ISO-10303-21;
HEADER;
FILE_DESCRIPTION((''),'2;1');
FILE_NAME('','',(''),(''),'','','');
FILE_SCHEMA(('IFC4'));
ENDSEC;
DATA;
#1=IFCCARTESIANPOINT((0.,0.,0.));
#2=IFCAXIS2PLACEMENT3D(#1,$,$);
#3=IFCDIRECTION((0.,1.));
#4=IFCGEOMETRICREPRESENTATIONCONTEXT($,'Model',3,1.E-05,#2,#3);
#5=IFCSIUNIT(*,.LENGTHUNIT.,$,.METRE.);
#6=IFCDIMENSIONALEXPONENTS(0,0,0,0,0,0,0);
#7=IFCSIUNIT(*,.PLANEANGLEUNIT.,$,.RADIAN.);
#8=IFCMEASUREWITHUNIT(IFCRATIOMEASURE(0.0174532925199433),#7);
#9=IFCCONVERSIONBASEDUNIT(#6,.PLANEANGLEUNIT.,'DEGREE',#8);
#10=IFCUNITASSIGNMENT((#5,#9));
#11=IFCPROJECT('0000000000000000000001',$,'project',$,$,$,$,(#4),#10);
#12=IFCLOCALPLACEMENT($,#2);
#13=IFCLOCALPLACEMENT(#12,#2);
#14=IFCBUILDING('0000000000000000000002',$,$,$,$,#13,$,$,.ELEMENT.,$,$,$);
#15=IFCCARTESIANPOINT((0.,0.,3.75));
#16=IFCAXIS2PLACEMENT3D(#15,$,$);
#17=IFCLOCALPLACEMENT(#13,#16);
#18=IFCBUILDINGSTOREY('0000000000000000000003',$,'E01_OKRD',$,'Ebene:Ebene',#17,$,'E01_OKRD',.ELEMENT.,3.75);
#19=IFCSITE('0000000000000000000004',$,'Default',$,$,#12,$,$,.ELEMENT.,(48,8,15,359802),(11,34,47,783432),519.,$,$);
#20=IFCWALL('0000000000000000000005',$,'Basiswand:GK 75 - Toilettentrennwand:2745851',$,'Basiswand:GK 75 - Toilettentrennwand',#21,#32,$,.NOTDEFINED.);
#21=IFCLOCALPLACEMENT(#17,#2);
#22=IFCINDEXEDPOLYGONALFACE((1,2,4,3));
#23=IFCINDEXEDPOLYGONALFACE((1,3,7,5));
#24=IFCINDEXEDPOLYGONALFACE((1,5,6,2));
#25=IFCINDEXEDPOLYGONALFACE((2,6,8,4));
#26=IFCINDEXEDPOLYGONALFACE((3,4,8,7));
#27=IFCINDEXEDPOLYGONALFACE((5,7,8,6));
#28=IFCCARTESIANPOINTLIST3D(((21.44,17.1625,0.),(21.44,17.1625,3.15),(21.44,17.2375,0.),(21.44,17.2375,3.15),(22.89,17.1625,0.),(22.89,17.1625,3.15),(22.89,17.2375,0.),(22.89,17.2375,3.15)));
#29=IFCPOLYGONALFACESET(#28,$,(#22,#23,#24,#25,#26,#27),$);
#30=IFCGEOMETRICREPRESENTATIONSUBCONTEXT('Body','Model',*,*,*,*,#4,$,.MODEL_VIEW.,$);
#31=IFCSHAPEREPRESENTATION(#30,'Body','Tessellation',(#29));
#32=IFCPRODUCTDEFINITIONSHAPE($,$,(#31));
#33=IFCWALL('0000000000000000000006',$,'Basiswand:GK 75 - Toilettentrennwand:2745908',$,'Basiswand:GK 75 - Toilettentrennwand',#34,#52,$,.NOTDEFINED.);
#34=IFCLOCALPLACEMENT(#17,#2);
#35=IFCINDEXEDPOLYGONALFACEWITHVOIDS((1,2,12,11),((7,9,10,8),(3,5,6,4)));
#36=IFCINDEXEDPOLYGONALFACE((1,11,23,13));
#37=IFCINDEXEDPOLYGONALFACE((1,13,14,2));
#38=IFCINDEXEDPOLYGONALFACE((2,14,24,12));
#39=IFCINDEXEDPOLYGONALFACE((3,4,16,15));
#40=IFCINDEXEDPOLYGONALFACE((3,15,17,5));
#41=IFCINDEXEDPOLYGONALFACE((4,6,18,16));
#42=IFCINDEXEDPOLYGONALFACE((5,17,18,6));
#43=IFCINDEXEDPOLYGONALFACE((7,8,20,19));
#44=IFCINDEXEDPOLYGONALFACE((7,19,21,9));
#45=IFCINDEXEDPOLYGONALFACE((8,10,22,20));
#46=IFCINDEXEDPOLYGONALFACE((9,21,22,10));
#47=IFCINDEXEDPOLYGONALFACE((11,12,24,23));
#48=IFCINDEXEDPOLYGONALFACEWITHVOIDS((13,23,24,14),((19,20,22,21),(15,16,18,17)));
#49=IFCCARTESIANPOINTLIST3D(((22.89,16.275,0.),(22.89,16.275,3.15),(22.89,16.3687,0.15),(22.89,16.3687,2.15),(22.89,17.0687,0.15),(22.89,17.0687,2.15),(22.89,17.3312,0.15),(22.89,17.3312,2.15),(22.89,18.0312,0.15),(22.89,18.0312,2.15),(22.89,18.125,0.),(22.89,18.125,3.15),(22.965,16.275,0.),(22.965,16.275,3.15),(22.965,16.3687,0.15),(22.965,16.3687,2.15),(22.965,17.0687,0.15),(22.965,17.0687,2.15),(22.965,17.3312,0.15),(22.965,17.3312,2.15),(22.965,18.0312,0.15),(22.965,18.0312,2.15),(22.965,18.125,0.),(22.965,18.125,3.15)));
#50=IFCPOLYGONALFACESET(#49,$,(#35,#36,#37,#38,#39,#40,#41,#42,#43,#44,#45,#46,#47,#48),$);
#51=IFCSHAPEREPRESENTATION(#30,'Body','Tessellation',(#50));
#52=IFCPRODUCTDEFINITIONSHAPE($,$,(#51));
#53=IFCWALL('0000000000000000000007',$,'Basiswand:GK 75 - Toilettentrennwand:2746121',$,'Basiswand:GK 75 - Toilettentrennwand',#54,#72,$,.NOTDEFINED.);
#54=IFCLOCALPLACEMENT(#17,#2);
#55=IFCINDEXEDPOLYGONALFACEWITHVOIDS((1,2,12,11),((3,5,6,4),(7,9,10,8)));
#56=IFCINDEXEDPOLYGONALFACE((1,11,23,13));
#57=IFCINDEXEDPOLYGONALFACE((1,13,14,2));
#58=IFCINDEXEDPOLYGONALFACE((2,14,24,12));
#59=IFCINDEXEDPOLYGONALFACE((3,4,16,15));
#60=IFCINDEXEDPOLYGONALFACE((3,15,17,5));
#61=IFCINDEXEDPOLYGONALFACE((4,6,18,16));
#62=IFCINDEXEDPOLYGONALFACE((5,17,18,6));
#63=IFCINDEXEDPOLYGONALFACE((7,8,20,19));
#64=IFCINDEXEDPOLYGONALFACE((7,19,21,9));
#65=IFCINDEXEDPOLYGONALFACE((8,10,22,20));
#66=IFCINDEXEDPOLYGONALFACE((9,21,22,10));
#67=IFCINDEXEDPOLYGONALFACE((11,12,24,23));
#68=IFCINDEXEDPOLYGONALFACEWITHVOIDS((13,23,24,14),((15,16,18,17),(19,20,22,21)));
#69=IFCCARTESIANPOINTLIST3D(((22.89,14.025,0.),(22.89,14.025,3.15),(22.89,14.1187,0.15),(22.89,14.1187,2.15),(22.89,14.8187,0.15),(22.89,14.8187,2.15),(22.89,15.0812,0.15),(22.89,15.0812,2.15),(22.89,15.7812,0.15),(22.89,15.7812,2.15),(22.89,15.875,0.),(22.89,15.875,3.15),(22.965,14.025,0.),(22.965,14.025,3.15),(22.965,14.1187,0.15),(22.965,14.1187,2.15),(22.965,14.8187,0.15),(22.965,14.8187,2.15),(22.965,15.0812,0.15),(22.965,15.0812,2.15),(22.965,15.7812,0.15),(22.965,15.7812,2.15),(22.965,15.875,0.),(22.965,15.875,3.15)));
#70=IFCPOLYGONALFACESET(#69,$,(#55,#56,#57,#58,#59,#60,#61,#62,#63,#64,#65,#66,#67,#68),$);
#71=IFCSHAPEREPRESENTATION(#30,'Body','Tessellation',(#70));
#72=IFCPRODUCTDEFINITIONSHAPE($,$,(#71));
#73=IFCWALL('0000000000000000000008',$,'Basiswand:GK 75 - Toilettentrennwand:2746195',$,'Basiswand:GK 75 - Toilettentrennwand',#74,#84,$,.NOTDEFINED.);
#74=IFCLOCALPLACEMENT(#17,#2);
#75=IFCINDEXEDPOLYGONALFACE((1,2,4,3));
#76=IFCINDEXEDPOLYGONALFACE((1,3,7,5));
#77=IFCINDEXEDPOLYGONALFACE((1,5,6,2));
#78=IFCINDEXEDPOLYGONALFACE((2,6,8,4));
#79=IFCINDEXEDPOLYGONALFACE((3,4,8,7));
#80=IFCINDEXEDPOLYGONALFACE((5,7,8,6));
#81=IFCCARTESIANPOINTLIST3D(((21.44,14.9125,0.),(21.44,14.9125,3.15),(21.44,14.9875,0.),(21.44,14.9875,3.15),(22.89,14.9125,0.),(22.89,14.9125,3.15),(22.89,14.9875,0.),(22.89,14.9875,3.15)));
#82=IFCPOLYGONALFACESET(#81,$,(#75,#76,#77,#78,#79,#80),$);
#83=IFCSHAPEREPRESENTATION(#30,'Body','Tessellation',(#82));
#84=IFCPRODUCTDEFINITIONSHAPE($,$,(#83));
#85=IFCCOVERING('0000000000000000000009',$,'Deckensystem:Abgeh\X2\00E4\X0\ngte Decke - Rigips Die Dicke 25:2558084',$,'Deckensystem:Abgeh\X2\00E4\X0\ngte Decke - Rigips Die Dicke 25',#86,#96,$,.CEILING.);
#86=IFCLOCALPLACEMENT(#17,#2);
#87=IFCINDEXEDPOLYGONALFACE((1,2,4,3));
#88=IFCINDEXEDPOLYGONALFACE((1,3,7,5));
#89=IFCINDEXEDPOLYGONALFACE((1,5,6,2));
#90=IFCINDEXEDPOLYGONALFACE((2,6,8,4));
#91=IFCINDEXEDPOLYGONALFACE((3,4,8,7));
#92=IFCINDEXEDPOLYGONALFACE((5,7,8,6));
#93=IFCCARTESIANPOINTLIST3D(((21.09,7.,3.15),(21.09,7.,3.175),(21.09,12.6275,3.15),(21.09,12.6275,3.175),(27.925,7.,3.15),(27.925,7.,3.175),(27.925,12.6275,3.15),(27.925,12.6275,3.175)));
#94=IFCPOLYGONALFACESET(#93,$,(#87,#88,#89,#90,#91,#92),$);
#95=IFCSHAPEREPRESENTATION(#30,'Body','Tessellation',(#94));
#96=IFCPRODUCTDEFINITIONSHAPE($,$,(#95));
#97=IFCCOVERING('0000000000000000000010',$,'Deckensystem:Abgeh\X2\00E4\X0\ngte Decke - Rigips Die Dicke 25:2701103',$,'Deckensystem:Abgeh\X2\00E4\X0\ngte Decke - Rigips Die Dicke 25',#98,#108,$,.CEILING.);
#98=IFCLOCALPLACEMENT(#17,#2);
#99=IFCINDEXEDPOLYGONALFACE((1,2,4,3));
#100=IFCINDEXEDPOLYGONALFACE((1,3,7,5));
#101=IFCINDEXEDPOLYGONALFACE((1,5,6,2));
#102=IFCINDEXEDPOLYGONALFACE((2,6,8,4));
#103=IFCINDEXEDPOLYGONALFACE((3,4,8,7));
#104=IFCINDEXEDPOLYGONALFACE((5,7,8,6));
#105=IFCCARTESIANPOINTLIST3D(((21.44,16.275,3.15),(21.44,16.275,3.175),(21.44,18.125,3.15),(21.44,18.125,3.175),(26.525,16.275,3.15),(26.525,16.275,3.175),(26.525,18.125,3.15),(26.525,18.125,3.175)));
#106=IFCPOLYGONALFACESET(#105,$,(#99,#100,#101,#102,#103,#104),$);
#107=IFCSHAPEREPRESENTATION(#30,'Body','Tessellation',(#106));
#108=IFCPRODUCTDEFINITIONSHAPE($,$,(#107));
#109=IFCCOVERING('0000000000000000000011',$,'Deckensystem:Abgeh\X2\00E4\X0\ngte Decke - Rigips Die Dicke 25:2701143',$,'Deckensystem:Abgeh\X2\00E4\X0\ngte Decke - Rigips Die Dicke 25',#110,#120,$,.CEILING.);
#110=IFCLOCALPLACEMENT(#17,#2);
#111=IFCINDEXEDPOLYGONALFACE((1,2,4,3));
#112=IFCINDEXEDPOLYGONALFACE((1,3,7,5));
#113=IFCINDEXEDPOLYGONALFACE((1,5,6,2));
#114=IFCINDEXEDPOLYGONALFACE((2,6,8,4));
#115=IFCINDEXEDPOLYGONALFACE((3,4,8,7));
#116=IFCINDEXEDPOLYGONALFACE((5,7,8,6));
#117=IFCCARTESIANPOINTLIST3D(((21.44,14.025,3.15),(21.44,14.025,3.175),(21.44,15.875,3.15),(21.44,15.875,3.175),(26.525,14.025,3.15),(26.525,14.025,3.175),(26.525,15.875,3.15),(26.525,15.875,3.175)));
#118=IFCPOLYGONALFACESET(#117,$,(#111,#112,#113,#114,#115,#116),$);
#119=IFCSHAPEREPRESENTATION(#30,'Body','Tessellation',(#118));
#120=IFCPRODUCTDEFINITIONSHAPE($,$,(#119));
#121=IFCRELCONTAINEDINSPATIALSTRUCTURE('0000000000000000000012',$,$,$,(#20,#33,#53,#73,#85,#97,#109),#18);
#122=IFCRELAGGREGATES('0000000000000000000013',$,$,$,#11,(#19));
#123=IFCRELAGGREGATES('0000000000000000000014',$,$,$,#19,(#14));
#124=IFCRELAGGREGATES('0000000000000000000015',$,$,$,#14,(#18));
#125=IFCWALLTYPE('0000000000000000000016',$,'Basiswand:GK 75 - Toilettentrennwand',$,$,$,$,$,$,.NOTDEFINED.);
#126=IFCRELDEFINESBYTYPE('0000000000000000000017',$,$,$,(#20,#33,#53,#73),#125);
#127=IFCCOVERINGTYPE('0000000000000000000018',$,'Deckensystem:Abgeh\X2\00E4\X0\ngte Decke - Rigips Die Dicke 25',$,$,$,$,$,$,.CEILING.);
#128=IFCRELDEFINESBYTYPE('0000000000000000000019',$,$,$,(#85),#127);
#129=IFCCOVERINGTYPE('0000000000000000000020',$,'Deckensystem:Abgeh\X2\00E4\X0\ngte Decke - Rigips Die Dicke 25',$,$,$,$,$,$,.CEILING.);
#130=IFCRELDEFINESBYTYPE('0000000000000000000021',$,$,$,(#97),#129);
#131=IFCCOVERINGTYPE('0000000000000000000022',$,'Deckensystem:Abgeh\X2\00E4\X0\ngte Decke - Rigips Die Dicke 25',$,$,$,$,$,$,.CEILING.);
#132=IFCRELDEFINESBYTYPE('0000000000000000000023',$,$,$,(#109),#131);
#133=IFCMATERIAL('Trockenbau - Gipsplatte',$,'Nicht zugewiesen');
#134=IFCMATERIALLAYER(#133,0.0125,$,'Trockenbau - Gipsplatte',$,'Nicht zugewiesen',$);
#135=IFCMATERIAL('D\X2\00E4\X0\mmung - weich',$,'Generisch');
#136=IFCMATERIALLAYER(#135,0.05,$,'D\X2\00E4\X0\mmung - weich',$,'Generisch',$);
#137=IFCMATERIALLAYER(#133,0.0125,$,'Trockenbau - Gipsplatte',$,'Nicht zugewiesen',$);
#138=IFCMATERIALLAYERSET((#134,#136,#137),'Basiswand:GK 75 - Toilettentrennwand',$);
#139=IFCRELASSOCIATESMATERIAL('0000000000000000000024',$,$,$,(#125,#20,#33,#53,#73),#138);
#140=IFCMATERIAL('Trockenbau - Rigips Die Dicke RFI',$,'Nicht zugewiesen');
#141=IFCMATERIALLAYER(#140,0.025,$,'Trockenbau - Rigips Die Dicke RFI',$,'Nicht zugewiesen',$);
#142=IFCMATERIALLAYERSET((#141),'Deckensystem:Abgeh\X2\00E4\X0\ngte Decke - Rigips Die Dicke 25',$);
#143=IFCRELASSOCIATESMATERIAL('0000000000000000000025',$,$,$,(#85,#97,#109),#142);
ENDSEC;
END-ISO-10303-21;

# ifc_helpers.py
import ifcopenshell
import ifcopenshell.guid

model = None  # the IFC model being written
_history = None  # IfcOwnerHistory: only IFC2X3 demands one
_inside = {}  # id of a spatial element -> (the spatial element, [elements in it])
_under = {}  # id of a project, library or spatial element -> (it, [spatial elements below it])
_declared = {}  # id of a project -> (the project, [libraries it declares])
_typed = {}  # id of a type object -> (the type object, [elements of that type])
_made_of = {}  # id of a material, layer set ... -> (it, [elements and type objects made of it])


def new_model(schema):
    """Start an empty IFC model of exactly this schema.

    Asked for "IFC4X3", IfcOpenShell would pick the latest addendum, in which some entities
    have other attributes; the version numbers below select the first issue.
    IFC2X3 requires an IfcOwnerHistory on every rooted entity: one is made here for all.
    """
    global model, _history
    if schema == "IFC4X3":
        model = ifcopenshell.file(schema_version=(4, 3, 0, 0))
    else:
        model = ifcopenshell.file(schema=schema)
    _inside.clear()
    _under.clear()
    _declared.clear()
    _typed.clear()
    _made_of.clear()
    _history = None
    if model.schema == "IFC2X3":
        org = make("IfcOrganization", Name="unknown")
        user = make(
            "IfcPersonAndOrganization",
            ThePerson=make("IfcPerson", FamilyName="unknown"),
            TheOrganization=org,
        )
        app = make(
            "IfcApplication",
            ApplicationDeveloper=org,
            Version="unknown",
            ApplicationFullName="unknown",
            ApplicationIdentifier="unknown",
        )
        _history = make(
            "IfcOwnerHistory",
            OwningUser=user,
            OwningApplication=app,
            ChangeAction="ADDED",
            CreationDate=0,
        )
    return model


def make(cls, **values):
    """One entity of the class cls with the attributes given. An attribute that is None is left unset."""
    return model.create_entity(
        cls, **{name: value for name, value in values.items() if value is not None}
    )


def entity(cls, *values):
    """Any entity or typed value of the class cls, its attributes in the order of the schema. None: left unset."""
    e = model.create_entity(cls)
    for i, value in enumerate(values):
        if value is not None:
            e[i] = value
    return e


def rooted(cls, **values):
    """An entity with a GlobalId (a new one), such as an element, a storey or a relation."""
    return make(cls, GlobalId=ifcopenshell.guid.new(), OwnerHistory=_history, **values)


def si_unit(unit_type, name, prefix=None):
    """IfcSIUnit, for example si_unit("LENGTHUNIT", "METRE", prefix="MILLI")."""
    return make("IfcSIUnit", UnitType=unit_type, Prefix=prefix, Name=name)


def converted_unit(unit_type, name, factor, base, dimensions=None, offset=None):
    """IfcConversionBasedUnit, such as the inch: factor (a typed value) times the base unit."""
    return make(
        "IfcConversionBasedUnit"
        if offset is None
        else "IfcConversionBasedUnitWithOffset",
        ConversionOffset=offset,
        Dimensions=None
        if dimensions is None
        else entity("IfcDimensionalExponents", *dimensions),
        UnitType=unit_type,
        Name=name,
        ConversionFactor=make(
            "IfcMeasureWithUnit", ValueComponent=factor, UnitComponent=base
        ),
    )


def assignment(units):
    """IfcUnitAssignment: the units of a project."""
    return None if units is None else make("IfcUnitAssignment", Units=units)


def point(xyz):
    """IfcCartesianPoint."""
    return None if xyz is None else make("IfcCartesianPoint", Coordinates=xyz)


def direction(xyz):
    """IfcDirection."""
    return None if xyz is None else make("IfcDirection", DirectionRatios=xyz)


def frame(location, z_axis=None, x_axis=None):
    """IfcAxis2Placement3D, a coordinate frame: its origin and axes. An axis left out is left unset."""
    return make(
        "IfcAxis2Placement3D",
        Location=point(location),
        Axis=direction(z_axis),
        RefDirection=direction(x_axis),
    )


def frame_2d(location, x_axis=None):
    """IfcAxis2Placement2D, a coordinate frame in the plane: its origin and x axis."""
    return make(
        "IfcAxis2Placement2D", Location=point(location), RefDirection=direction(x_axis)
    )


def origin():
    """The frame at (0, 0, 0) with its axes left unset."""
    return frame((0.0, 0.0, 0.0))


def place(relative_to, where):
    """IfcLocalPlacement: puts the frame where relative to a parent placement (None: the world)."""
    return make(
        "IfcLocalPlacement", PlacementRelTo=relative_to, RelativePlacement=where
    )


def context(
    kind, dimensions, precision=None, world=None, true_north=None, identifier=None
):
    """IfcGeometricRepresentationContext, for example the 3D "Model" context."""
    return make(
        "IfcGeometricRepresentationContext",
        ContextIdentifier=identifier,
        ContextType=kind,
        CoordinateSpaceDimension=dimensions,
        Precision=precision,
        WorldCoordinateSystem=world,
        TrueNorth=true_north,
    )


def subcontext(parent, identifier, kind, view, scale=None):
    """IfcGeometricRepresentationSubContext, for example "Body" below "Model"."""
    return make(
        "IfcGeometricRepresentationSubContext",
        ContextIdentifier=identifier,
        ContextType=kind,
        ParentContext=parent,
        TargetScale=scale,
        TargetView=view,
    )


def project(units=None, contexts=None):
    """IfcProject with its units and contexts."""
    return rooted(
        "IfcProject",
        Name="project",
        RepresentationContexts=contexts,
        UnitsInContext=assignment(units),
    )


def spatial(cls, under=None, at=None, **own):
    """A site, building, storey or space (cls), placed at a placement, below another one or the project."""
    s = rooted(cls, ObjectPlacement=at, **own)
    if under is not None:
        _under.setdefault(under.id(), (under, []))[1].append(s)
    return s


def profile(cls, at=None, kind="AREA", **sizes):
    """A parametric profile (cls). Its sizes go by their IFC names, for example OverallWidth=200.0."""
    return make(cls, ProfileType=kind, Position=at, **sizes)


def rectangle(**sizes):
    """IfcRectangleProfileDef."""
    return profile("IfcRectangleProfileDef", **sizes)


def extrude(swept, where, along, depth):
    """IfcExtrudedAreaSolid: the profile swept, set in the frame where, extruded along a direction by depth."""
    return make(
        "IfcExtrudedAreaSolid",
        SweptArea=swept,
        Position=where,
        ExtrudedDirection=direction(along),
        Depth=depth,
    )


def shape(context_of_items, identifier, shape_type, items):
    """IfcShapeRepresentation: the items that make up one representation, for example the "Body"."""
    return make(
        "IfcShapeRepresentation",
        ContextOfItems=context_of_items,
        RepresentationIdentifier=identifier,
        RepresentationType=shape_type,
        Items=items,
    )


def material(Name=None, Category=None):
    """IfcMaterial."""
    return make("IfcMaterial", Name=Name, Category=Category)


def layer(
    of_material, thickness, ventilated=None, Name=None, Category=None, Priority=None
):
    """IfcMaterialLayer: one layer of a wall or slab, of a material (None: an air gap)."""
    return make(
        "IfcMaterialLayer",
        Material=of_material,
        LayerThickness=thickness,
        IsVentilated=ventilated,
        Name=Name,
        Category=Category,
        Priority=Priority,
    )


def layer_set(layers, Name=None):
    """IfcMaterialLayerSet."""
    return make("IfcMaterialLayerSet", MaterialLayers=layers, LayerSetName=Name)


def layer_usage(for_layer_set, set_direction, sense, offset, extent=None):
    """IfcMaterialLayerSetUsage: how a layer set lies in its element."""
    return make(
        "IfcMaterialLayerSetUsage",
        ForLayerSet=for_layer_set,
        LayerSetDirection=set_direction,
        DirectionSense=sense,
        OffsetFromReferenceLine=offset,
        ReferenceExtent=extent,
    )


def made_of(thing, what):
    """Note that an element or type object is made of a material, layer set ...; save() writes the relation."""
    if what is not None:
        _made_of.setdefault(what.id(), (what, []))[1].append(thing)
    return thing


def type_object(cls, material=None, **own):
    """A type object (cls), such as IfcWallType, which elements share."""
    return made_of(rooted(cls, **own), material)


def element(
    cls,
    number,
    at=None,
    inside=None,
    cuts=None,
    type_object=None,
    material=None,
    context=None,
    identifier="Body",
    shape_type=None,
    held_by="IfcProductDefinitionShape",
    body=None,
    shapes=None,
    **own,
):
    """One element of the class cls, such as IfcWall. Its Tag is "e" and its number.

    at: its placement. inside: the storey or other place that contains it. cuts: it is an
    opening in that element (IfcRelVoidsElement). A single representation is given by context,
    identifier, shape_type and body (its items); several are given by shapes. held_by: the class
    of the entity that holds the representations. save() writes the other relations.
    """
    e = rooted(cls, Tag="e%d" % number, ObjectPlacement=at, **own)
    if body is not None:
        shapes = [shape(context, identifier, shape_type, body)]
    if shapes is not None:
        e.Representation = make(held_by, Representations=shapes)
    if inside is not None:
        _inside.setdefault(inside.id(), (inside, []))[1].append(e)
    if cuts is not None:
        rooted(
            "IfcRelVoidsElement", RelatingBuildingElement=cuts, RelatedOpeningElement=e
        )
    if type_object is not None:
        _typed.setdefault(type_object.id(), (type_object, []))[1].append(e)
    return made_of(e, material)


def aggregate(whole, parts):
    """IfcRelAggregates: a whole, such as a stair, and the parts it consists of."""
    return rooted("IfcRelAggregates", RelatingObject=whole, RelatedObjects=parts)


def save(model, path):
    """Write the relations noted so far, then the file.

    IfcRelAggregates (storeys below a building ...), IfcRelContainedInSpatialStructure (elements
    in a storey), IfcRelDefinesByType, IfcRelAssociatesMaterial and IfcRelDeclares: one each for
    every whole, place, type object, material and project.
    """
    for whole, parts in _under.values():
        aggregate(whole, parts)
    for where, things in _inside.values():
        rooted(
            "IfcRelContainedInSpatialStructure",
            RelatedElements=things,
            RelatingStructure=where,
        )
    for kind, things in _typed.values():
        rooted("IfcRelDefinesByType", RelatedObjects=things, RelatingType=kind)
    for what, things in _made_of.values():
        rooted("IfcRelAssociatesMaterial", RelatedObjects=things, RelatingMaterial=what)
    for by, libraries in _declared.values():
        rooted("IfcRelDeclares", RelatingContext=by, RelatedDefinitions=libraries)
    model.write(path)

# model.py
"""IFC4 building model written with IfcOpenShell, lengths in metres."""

from ifc_helpers import new_model, entity, si_unit, converted_unit, direction, frame, frame_2d, origin, place, context, subcontext, project, spatial, rectangle, extrude, material, layer, layer_set, layer_usage, type_object, element, save


model = new_model("IFC4")

# Units and contexts
model_context = context("Model", 3, precision=1e-05, world=origin(), true_north=direction((0.0, 1.0)))
body_context = subcontext(model_context, "Body", "Model", "MODEL_VIEW")
ifc_project = project(units=[si_unit("LENGTHUNIT", "METRE"), converted_unit("PLANEANGLEUNIT", "DEGREE", entity("IfcRatioMeasure", 0.0174532925199433), si_unit("PLANEANGLEUNIT", "RADIAN"), dimensions=[0, 0, 0, 0, 0, 0, 0])], contexts=[model_context])

# Site, building, storey
site_placement = place(None, frame((0.0, 0.0, 0.0)))
site = spatial("IfcSite", under=ifc_project, at=site_placement, Name="Default", CompositionType="ELEMENT", RefLatitude=(48, 8, 15, 359802), RefLongitude=(11, 34, 47, 783432), RefElevation=519.0)
building_placement = place(site_placement, origin())
building = spatial("IfcBuilding", under=site, at=building_placement, CompositionType="ELEMENT")
storey_placement = place(building_placement, frame((0.0, 0.0, 3.75)))
storey = spatial("IfcBuildingStorey", under=building, at=storey_placement, Name="E01_OKRD", ObjectType="Ebene:Ebene", LongName="E01_OKRD", CompositionType="ELEMENT", Elevation=3.75)

# Wall
ifc_material_1 = material(Name="Trockenbau - Gipsplatte", Category="Nicht zugewiesen")
ifc_material_2 = material(Name="Dämmung - weich", Category="Generisch")
ifc_layer_1 = layer(ifc_material_1, 0.0125, Name="Trockenbau - Gipsplatte", Category="Nicht zugewiesen")
ifc_layer_2 = layer(ifc_material_2, 0.05, Name="Dämmung - weich", Category="Generisch")
ifc_layer_3 = layer(ifc_material_1, 0.0125, Name="Trockenbau - Gipsplatte", Category="Nicht zugewiesen")
ifc_layer_set_1 = layer_set([ifc_layer_1, ifc_layer_2, ifc_layer_3], Name="Basiswand:GK 75 - Toilettentrennwand")
ifc_layer_usage_1 = layer_usage(ifc_layer_set_1, "AXIS2", "POSITIVE", -0.0375)
wall_type_1 = type_object("IfcWallType", Name="Basiswand:GK 75 - Toilettentrennwand", PredefinedType="NOTDEFINED", material=ifc_layer_set_1)
wall_1_placement = place(storey_placement, frame((21.44, 17.2, 0.0)))
element("IfcWall", 1, at=wall_1_placement, inside=storey, type_object=wall_type_1, material=ifc_layer_usage_1, Name="Basiswand:GK 75 - Toilettentrennwand:2745851", ObjectType="Basiswand:GK 75 - Toilettentrennwand", PredefinedType="NOTDEFINED", context=body_context, shape_type="SweptSolid", body=[
    extrude(rectangle(XDim=1.45, YDim=0.075, at=frame_2d((0.725, 0.0), x_axis=(-1.0, 0.0))), origin(), (0.0, 0.0, 1.0), 3.15),
])

# Walls, openings
ifc_layer_usage_2 = layer_usage(ifc_layer_set_1, "AXIS2", "NEGATIVE", 0.0375)
wall_2_placement = place(storey_placement, frame((22.9275, 18.125, 0.0), z_axis=(0.0, 0.0, 1.0), x_axis=(0.0, -1.0, 0.0)))
wall_2 = element("IfcWall", 2, at=wall_2_placement, inside=storey, type_object=wall_type_1, material=ifc_layer_usage_2, Name="Basiswand:GK 75 - Toilettentrennwand:2745908", ObjectType="Basiswand:GK 75 - Toilettentrennwand", PredefinedType="NOTDEFINED", context=body_context, shape_type="SweptSolid", body=[
    extrude(rectangle(XDim=1.85, YDim=0.075, at=frame_2d((0.925, 0.0), x_axis=(-1.0, 0.0))), origin(), (0.0, 0.0, 1.0), 3.15),
])
opening_1_placement = place(wall_2_placement, frame((1.7563, -0.0375, 0.15)))
element("IfcOpeningElement", 3, at=opening_1_placement, cuts=wall_2, ObjectType="Opening", PredefinedType="OPENING", context=body_context, shape_type="SweptSolid", body=[
    extrude(rectangle(XDim=2.0, YDim=0.7, at=frame_2d((0.0, 0.0), x_axis=(1.0, 0.0))), frame((-0.35, 0.0, 1.0), z_axis=(0.0, 1.0, 0.0), x_axis=(0.0, 0.0, -1.0)), (0.0, 0.0, 1.0), 0.075),
])
opening_2_placement = place(wall_2_placement, frame((0.7937, -0.0375, 0.15)))
element("IfcOpeningElement", 4, at=opening_2_placement, cuts=wall_2, ObjectType="Opening", PredefinedType="OPENING", context=body_context, shape_type="SweptSolid", body=[
    extrude(rectangle(XDim=2.0, YDim=0.7, at=frame_2d((0.0, 0.0), x_axis=(1.0, 0.0))), frame((-0.35, 0.0, 1.0), z_axis=(0.0, 1.0, 0.0), x_axis=(0.0, 0.0, -1.0)), (0.0, 0.0, 1.0), 0.075),
])
ifc_layer_usage_3 = layer_usage(ifc_layer_set_1, "AXIS2", "NEGATIVE", 0.0375)
wall_3_placement = place(storey_placement, frame((22.9275, 15.875, 0.0), z_axis=(0.0, 0.0, 1.0), x_axis=(0.0, -1.0, 0.0)))
wall_3 = element("IfcWall", 5, at=wall_3_placement, inside=storey, type_object=wall_type_1, material=ifc_layer_usage_3, Name="Basiswand:GK 75 - Toilettentrennwand:2746121", ObjectType="Basiswand:GK 75 - Toilettentrennwand", PredefinedType="NOTDEFINED", context=body_context, shape_type="SweptSolid", body=[
    extrude(rectangle(XDim=1.85, YDim=0.075, at=frame_2d((0.925, 0.0), x_axis=(-1.0, 0.0))), origin(), (0.0, 0.0, 1.0), 3.15),
])
opening_3_placement = place(wall_3_placement, frame((0.7938, -0.0375, 0.15)))
element("IfcOpeningElement", 6, at=opening_3_placement, cuts=wall_3, ObjectType="Opening", PredefinedType="OPENING", context=body_context, shape_type="SweptSolid", body=[
    extrude(rectangle(XDim=2.0, YDim=0.7, at=frame_2d((0.0, 0.0), x_axis=(1.0, 0.0))), frame((-0.35, 0.0, 1.0), z_axis=(0.0, 1.0, 0.0), x_axis=(0.0, 0.0, -1.0)), (0.0, 0.0, 1.0), 0.075),
])
opening_4_placement = place(wall_3_placement, frame((1.7562, -0.0375, 0.15)))
element("IfcOpeningElement", 7, at=opening_4_placement, cuts=wall_3, ObjectType="Opening", PredefinedType="OPENING", context=body_context, shape_type="SweptSolid", body=[
    extrude(rectangle(XDim=2.0, YDim=0.7, at=frame_2d((0.0, 0.0), x_axis=(1.0, 0.0))), frame((-0.35, 0.0, 1.0), z_axis=(0.0, 1.0, 0.0), x_axis=(0.0, 0.0, -1.0)), (0.0, 0.0, 1.0), 0.075),
])

# Wall
ifc_layer_usage_4 = layer_usage(ifc_layer_set_1, "AXIS2", "NEGATIVE", 0.0375)
wall_4_placement = place(storey_placement, frame((22.89, 14.95, 0.0), z_axis=(0.0, 0.0, 1.0), x_axis=(-1.0, 0.0, 0.0)))
element("IfcWall", 8, at=wall_4_placement, inside=storey, type_object=wall_type_1, material=ifc_layer_usage_4, Name="Basiswand:GK 75 - Toilettentrennwand:2746195", ObjectType="Basiswand:GK 75 - Toilettentrennwand", PredefinedType="NOTDEFINED", context=body_context, shape_type="SweptSolid", body=[
    extrude(rectangle(XDim=1.45, YDim=0.075, at=frame_2d((0.725, 0.0), x_axis=(-1.0, 0.0))), origin(), (0.0, 0.0, 1.0), 3.15),
])

# Coverings
ifc_material_3 = material(Name="Trockenbau - Rigips Die Dicke RFI", Category="Nicht zugewiesen")
ifc_layer_4 = layer(ifc_material_3, 0.025, Name="Trockenbau - Rigips Die Dicke RFI", Category="Nicht zugewiesen")
ifc_layer_set_2 = layer_set([ifc_layer_4], Name="Deckensystem:Abgehängte Decke - Rigips Die Dicke 25")
ifc_layer_usage_5 = layer_usage(ifc_layer_set_2, "AXIS3", "POSITIVE", 0.0)
covering_type_1 = type_object("IfcCoveringType", Name="Deckensystem:Abgehängte Decke - Rigips Die Dicke 25", PredefinedType="CEILING")
covering_1_placement = place(storey_placement, frame((21.09, 7.0, 3.15)))
element("IfcCovering", 9, at=covering_1_placement, inside=storey, type_object=covering_type_1, material=ifc_layer_usage_5, Name="Deckensystem:Abgehängte Decke - Rigips Die Dicke 25:2558084", ObjectType="Deckensystem:Abgehängte Decke - Rigips Die Dicke 25", PredefinedType="CEILING", context=body_context, shape_type="SweptSolid", body=[
    extrude(rectangle(XDim=5.6275, YDim=6.835, at=frame_2d((0.0, 0.0), x_axis=(1.0, 0.0))), frame((3.4175, 2.8137, 0.0), z_axis=(0.0, 0.0, 1.0), x_axis=(0.0, -1.0, 0.0)), (0.0, 0.0, 1.0), 0.025),
])
ifc_layer_usage_6 = layer_usage(ifc_layer_set_2, "AXIS3", "POSITIVE", 0.0)
covering_type_2 = type_object("IfcCoveringType", Name="Deckensystem:Abgehängte Decke - Rigips Die Dicke 25", PredefinedType="CEILING")
covering_2_placement = place(storey_placement, frame((21.44, 16.275, 3.15)))
element("IfcCovering", 10, at=covering_2_placement, inside=storey, type_object=covering_type_2, material=ifc_layer_usage_6, Name="Deckensystem:Abgehängte Decke - Rigips Die Dicke 25:2701103", ObjectType="Deckensystem:Abgehängte Decke - Rigips Die Dicke 25", PredefinedType="CEILING", context=body_context, shape_type="SweptSolid", body=[
    extrude(rectangle(XDim=5.085, YDim=1.85, at=frame_2d((0.0, 0.0), x_axis=(1.0, 0.0))), frame((2.5425, 0.925, 0.0), z_axis=(0.0, 0.0, 1.0), x_axis=(-1.0, 0.0, 0.0)), (0.0, 0.0, 1.0), 0.025),
])
ifc_layer_usage_7 = layer_usage(ifc_layer_set_2, "AXIS3", "POSITIVE", 0.0)
covering_type_3 = type_object("IfcCoveringType", Name="Deckensystem:Abgehängte Decke - Rigips Die Dicke 25", PredefinedType="CEILING")
covering_3_placement = place(storey_placement, frame((21.44, 14.025, 3.15)))
element("IfcCovering", 11, at=covering_3_placement, inside=storey, type_object=covering_type_3, material=ifc_layer_usage_7, Name="Deckensystem:Abgehängte Decke - Rigips Die Dicke 25:2701143", ObjectType="Deckensystem:Abgehängte Decke - Rigips Die Dicke 25", PredefinedType="CEILING", context=body_context, shape_type="SweptSolid", body=[
    extrude(rectangle(XDim=5.085, YDim=1.85, at=frame_2d((0.0, 0.0), x_axis=(1.0, 0.0))), frame((2.5425, 0.925, 0.0), z_axis=(0.0, 0.0, 1.0), x_axis=(-1.0, 0.0, 0.0)), (0.0, 0.0, 1.0), 0.025),
])

save(model, "model.ifc")
